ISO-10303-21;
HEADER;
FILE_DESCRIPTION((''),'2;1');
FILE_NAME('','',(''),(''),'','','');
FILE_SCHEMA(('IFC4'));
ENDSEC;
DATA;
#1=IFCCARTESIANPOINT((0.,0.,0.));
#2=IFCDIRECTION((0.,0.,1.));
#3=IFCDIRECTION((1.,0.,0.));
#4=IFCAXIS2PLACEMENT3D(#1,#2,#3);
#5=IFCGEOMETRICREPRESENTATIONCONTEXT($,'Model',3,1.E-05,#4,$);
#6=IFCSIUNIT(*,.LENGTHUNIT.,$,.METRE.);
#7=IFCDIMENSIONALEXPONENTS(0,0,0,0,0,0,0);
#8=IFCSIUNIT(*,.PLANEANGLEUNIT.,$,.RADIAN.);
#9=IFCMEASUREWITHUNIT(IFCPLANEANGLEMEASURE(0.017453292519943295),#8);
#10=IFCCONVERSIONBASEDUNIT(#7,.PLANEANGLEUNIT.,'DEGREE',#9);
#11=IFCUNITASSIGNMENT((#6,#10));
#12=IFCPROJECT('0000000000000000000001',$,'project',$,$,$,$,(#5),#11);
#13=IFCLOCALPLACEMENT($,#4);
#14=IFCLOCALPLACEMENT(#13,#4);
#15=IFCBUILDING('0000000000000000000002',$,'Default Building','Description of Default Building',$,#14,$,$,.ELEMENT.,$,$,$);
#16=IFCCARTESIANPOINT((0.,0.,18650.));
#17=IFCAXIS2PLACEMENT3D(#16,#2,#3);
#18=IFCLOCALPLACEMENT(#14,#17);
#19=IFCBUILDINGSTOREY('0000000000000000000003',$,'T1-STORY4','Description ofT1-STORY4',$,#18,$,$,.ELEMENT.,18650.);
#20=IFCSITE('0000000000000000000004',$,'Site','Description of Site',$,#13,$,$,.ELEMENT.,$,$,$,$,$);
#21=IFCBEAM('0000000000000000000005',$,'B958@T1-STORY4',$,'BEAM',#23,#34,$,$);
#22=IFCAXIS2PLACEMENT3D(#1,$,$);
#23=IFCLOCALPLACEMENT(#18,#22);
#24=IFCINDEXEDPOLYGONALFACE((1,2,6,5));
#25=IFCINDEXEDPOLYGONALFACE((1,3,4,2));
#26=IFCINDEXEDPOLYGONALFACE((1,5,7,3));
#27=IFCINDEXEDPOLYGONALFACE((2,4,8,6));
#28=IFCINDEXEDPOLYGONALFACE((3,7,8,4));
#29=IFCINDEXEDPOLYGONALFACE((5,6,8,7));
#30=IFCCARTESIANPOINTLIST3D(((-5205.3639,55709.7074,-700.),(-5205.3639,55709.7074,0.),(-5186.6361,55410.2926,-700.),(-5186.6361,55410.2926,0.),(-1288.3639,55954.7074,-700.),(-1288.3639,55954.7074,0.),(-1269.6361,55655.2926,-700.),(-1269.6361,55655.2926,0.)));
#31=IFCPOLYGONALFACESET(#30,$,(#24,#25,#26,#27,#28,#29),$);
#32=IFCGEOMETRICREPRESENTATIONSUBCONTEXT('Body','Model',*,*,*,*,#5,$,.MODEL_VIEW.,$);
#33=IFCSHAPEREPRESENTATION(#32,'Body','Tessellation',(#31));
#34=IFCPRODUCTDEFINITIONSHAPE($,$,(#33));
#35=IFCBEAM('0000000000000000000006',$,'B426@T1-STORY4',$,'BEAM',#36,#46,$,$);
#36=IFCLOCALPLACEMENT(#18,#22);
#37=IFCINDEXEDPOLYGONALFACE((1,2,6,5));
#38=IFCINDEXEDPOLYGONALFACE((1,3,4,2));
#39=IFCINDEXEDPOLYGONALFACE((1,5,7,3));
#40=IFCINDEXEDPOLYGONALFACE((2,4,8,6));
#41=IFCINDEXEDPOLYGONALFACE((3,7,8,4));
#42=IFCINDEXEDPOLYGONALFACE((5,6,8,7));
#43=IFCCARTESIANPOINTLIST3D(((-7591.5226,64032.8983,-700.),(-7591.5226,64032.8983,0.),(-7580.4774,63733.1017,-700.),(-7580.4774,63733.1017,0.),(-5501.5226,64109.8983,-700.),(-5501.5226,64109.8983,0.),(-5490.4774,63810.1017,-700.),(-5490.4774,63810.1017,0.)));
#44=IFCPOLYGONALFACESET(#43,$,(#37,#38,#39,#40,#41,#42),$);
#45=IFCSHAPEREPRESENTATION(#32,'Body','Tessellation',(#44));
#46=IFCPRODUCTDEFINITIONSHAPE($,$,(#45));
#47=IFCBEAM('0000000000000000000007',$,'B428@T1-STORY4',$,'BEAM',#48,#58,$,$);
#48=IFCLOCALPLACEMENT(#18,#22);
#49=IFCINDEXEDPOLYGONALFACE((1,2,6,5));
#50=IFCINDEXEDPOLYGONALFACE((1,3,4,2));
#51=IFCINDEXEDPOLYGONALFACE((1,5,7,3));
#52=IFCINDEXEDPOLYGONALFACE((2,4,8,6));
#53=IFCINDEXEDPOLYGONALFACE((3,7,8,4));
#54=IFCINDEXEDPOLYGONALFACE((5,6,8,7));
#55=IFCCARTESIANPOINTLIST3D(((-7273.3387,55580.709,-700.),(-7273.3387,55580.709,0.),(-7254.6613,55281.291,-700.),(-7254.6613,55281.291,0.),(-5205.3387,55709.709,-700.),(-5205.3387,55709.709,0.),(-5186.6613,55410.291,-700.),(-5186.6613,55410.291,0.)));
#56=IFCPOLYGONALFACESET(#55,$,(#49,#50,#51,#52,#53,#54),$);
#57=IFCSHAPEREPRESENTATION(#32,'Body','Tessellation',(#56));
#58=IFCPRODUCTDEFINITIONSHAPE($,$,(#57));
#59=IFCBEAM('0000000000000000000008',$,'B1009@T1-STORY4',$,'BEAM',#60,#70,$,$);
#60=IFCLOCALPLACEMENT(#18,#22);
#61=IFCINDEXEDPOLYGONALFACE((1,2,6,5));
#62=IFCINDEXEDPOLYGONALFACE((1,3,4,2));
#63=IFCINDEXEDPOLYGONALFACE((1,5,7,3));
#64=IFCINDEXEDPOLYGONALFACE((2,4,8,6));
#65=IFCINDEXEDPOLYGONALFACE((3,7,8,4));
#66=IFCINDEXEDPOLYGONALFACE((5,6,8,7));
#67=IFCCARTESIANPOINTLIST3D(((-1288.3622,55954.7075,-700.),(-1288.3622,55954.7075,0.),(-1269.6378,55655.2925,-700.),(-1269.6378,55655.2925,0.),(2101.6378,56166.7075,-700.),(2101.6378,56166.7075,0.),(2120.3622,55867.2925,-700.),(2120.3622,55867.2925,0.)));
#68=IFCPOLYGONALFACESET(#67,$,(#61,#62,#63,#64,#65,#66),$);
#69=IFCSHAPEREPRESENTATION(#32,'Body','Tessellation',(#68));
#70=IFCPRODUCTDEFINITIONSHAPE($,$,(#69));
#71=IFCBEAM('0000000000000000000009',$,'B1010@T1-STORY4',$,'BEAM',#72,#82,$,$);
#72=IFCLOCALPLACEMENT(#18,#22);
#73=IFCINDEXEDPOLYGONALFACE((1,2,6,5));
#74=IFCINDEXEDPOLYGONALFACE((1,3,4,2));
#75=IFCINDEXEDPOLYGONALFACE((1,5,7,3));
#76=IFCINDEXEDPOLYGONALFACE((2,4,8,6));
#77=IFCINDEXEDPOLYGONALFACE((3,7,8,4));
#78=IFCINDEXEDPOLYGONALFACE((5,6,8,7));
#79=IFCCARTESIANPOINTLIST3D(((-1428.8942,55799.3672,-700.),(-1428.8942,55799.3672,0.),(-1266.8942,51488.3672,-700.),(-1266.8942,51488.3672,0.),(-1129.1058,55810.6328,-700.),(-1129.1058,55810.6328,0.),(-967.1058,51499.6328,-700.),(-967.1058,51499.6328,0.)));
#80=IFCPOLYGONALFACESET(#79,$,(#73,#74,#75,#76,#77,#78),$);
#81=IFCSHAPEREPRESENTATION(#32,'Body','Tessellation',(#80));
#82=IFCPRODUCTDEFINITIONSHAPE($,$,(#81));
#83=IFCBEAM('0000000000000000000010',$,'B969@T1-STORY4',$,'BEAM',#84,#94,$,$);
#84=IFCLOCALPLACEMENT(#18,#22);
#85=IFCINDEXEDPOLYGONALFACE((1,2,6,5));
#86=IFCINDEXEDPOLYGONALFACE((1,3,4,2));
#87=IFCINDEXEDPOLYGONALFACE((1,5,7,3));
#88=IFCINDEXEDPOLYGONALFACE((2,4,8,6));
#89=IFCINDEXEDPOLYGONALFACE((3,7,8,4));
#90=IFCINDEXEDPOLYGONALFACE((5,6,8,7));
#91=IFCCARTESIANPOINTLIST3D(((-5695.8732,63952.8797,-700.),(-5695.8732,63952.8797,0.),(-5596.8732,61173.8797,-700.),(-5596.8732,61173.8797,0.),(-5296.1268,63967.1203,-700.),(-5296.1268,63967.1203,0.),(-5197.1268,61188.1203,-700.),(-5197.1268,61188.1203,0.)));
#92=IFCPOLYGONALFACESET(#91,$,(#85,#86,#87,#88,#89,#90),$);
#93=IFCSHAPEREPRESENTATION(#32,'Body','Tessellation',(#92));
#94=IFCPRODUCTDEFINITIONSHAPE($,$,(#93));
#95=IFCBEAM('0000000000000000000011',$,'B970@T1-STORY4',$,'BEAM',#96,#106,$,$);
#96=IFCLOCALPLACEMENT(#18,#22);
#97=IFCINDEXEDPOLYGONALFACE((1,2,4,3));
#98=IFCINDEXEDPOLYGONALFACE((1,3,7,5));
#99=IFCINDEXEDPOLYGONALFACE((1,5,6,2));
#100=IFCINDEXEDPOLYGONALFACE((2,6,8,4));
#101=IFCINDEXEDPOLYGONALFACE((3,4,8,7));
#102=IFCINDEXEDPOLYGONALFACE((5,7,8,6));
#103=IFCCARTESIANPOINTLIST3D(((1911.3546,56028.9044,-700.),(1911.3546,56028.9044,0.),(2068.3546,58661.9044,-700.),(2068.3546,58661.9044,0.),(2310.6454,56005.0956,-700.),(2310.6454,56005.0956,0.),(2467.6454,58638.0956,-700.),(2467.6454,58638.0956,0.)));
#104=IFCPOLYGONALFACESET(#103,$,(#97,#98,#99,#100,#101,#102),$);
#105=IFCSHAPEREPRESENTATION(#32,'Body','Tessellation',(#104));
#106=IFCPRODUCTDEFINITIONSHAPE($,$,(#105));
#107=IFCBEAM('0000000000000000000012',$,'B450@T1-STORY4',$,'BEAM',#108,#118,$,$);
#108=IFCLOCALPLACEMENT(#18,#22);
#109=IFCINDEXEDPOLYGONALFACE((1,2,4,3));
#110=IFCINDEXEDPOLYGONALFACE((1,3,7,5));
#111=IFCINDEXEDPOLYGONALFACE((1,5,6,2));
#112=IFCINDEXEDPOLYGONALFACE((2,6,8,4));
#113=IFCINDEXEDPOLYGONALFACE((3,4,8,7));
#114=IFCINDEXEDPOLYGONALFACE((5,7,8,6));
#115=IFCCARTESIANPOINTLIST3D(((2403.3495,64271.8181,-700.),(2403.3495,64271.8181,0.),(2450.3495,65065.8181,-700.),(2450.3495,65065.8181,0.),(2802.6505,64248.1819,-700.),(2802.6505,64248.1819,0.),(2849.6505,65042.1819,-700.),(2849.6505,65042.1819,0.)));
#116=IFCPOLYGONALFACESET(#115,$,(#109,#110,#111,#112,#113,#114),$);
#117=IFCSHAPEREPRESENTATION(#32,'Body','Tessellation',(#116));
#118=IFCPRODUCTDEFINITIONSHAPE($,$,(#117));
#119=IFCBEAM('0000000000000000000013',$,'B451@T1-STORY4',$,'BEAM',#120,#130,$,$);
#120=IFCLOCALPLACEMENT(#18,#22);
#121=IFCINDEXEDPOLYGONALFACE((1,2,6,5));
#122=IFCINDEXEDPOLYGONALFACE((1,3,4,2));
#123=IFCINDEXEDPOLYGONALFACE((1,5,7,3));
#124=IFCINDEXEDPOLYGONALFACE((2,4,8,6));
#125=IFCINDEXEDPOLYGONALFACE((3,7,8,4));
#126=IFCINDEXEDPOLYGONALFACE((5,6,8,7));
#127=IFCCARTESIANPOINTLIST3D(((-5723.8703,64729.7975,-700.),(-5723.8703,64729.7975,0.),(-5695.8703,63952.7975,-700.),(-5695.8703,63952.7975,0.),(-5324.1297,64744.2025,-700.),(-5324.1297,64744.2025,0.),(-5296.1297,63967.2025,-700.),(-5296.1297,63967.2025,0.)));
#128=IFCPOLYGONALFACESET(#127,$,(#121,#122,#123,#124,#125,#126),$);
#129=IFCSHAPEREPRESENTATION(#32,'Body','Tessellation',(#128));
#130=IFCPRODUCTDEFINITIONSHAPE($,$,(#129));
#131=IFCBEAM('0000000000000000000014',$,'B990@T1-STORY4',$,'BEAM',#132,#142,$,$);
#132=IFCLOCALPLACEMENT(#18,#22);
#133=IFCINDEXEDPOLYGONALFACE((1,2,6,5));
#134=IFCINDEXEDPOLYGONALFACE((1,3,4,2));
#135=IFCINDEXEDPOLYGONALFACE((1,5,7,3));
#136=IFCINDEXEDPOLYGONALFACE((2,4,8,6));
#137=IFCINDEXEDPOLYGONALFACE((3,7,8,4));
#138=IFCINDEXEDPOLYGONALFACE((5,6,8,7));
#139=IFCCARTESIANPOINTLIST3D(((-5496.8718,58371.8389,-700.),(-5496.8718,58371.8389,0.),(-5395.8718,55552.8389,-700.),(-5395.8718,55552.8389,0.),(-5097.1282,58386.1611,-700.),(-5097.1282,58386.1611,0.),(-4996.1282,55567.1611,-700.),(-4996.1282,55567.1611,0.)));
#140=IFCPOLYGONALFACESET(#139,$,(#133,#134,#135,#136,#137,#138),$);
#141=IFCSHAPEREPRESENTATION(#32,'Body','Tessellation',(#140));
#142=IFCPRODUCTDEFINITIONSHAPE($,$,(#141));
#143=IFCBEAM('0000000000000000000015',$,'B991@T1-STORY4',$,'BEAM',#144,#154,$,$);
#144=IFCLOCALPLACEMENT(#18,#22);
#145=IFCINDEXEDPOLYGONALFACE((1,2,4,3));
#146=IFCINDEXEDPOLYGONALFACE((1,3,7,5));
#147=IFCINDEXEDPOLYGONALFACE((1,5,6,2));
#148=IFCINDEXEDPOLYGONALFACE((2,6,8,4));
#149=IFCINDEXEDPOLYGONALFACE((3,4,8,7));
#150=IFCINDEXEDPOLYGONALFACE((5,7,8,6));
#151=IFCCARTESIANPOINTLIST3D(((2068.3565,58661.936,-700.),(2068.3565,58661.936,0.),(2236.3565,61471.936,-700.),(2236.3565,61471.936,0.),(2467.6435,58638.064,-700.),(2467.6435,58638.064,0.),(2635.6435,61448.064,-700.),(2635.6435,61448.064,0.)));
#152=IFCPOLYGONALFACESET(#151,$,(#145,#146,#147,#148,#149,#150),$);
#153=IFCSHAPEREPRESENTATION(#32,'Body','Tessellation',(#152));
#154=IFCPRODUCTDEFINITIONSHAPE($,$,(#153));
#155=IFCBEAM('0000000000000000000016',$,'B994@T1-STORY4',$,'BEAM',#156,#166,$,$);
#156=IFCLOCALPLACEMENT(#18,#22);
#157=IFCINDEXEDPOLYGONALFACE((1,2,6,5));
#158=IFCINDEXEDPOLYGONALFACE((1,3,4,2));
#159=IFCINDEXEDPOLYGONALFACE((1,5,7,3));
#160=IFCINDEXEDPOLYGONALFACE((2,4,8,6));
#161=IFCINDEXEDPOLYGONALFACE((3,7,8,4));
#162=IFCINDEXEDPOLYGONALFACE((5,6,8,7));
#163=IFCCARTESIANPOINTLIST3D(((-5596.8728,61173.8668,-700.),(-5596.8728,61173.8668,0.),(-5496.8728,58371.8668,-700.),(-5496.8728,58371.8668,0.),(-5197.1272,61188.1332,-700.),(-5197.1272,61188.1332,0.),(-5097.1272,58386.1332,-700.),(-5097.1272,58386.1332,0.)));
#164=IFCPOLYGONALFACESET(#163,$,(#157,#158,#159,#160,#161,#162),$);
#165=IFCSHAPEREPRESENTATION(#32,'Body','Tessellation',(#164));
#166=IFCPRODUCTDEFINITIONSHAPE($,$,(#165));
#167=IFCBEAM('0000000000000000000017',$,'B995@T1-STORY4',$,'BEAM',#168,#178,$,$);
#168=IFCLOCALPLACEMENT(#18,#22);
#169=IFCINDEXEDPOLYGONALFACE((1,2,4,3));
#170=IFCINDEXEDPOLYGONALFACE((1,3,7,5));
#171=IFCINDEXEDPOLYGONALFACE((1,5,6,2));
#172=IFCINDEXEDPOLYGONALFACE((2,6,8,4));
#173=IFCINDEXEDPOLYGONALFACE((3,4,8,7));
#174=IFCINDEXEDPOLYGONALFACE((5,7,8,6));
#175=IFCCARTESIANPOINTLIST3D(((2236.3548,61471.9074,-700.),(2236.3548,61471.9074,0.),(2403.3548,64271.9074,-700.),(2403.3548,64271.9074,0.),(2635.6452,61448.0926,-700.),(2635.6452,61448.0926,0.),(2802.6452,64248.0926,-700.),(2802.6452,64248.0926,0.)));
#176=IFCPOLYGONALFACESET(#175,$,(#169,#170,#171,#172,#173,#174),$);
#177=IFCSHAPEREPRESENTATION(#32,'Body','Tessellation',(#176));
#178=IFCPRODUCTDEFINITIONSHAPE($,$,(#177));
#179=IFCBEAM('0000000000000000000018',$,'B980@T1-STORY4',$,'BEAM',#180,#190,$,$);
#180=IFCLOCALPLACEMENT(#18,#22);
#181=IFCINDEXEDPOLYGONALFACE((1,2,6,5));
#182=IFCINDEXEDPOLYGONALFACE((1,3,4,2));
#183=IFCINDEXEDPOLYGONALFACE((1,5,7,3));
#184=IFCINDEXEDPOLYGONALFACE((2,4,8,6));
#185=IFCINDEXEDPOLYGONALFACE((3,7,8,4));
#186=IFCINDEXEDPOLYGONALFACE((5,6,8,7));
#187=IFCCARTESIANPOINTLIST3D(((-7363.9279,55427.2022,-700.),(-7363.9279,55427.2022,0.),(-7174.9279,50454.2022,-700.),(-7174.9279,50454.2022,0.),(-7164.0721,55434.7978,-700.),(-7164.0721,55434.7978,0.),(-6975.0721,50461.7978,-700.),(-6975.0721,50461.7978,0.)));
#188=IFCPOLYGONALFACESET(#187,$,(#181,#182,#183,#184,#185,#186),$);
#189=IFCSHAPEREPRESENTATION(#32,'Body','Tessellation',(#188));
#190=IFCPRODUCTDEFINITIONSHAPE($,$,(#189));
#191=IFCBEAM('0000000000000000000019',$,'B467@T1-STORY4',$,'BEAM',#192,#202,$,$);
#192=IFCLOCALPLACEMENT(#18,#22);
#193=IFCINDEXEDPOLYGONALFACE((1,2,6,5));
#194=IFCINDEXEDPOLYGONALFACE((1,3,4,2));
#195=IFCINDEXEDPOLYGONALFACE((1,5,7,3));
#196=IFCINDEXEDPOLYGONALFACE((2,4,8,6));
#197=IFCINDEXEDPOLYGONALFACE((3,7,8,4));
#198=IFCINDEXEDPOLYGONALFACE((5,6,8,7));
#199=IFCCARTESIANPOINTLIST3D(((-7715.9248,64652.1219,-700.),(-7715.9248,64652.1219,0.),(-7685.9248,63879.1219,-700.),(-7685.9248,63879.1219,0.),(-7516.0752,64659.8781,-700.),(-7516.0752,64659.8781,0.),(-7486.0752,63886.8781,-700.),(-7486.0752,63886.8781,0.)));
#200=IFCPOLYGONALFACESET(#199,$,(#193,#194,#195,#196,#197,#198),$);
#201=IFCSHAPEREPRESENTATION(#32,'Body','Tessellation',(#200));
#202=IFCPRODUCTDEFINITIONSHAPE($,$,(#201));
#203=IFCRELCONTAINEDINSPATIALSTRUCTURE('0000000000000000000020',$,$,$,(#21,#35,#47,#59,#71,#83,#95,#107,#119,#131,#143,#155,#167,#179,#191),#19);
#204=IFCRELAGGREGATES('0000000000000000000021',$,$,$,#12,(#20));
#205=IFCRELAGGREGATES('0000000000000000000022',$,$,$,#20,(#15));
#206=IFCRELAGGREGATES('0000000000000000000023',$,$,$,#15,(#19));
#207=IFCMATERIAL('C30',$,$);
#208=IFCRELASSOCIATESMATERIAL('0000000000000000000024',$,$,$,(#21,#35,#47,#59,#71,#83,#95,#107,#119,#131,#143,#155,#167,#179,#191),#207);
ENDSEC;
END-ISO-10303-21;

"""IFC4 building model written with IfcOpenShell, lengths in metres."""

from ifc_helpers import new_model, entity, si_unit, converted_unit, frame, origin_with_axes, place, context, subcontext, project, spatial, rectangle, extrude, material, element, save


model = new_model("IFC4")

# Units and contexts
model_context = context("Model", 3, precision=1e-05, world=origin_with_axes())
body_context = subcontext(model_context, "Body", "Model", "MODEL_VIEW")
ifc_project = project(units=[si_unit("LENGTHUNIT", "METRE"), converted_unit("PLANEANGLEUNIT", "DEGREE", entity("IfcPlaneAngleMeasure", 0.017453292519943295), si_unit("PLANEANGLEUNIT", "RADIAN"), dimensions=[0, 0, 0, 0, 0, 0, 0])], contexts=[model_context])

# Site, building, storey
site_placement = place(None, origin_with_axes())
site = spatial("IfcSite", under=ifc_project, at=site_placement, Name="Site", Description="Description of Site", CompositionType="ELEMENT")
building_placement = place(site_placement, origin_with_axes())
building = spatial("IfcBuilding", under=site, at=building_placement, Name="Default Building", Description="Description of Default Building", CompositionType="ELEMENT")
storey_placement = place(building_placement, frame((0.0, 0.0, 18650.0), z_axis=(0.0, 0.0, 1.0), x_axis=(1.0, 0.0, 0.0)))
storey = spatial("IfcBuildingStorey", under=building, at=storey_placement, Name="T1-STORY4", Description="Description ofT1-STORY4", CompositionType="ELEMENT", Elevation=18650.0)

# Beams
ifc_material_1 = material(Name="C30")
beam_1_placement = place(storey_placement, frame((-5196.0, 55560.0, -350.0), z_axis=(0.99805, 0.062426, 0.0), x_axis=(-0.062426, 0.99805, 0.0)))
element("IfcBeam", 1, at=beam_1_placement, inside=storey, material=ifc_material_1, Name="B958@T1-STORY4", ObjectType="BEAM", context=body_context, shape_type="SweptSolid", body=[
    extrude(rectangle(XDim=300.0, YDim=700.0), origin_with_axes(), (0.0, 0.0, 1.0), 3924.6546),
])
beam_2_placement = place(storey_placement, frame((-7586.0, 63883.0, -350.0), z_axis=(0.999322, 0.036817, 0.0), x_axis=(-0.036817, 0.999322, 0.0)))
element("IfcBeam", 2, at=beam_2_placement, inside=storey, material=ifc_material_1, Name="B426@T1-STORY4", ObjectType="BEAM", context=body_context, shape_type="SweptSolid", body=[
    extrude(rectangle(XDim=300.0, YDim=700.0), origin_with_axes(), (0.0, 0.0, 1.0), 2091.4179),
])
beam_3_placement = place(storey_placement, frame((-7264.0, 55431.0, -350.0), z_axis=(0.99806, 0.062258, 0.0), x_axis=(-0.062258, 0.99806, 0.0)))
element("IfcBeam", 3, at=beam_3_placement, inside=storey, material=ifc_material_1, Name="B428@T1-STORY4", ObjectType="BEAM", context=body_context, shape_type="SweptSolid", body=[
    extrude(rectangle(XDim=300.0, YDim=700.0), origin_with_axes(), (0.0, 0.0, 1.0), 2072.0195),
])
beam_4_placement = place(storey_placement, frame((-1279.0, 55805.0, -350.0), z_axis=(0.99805, 0.062415, 0.0), x_axis=(-0.062415, 0.99805, 0.0)))
element("IfcBeam", 4, at=beam_4_placement, inside=storey, material=ifc_material_1, Name="B1009@T1-STORY4", ObjectType="BEAM", context=body_context, shape_type="SweptSolid", body=[
    extrude(rectangle(XDim=300.0, YDim=700.0), origin_with_axes(), (0.0, 0.0, 1.0), 3396.6224),
])
beam_5_placement = place(storey_placement, frame((-1279.0, 55805.0, -350.0), z_axis=(0.037552, -0.999295, 0.0), x_axis=(0.999295, 0.037552, 0.0)))
element("IfcBeam", 5, at=beam_5_placement, inside=storey, material=ifc_material_1, Name="B1010@T1-STORY4", ObjectType="BEAM", context=body_context, shape_type="SweptSolid", body=[
    extrude(rectangle(XDim=300.0, YDim=700.0), origin_with_axes(), (0.0, 0.0, 1.0), 4314.0428),
])
beam_6_placement = place(storey_placement, frame((-5496.0, 63960.0, -350.0), z_axis=(0.035602, -0.999366, 0.0), x_axis=(0.999366, 0.035602, 0.0)))
element("IfcBeam", 6, at=beam_6_placement, inside=storey, material=ifc_material_1, Name="B969@T1-STORY4", ObjectType="BEAM", context=body_context, shape_type="SweptSolid", body=[
    extrude(rectangle(XDim=400.0, YDim=700.0), origin_with_axes(), (0.0, 0.0, 1.0), 2780.7628),
])
beam_7_placement = place(storey_placement, frame((2111.0, 56017.0, -350.0), z_axis=(0.059522, 0.998227, 0.0), x_axis=(-0.998227, 0.059522, 0.0)))
element("IfcBeam", 7, at=beam_7_placement, inside=storey, material=ifc_material_1, Name="B970@T1-STORY4", ObjectType="BEAM", context=body_context, shape_type="SweptSolid", body=[
    extrude(rectangle(XDim=400.0, YDim=700.0), origin_with_axes(), (0.0, 0.0, 1.0), 2637.6766),
])
beam_8_placement = place(storey_placement, frame((2603.0, 64260.0, -350.0), z_axis=(0.059091, 0.998253, 0.0), x_axis=(-0.998253, 0.059091, 0.0)))
element("IfcBeam", 8, at=beam_8_placement, inside=storey, material=ifc_material_1, Name="B450@T1-STORY4", ObjectType="BEAM", context=body_context, shape_type="SweptSolid", body=[
    extrude(rectangle(XDim=400.0, YDim=700.0), origin_with_axes(), (0.0, 0.0, 1.0), 795.3898),
])
beam_9_placement = place(storey_placement, frame((-5524.0, 64737.0, -350.0), z_axis=(0.036013, -0.999351, 0.0), x_axis=(0.999351, 0.036013, 0.0)))
element("IfcBeam", 9, at=beam_9_placement, inside=storey, material=ifc_material_1, Name="B451@T1-STORY4", ObjectType="BEAM", context=body_context, shape_type="SweptSolid", body=[
    extrude(rectangle(XDim=400.0, YDim=700.0), origin_with_axes(), (0.0, 0.0, 1.0), 777.5043),
])
beam_10_placement = place(storey_placement, frame((-5297.0, 58379.0, -350.0), z_axis=(0.035805, -0.999359, 0.0), x_axis=(0.999359, 0.035805, 0.0)))
element("IfcBeam", 10, at=beam_10_placement, inside=storey, material=ifc_material_1, Name="B990@T1-STORY4", ObjectType="BEAM", context=body_context, shape_type="SweptSolid", body=[
    extrude(rectangle(XDim=400.0, YDim=700.0), origin_with_axes(), (0.0, 0.0, 1.0), 2820.8087),
])
beam_11_placement = place(storey_placement, frame((2268.0, 58650.0, -350.0), z_axis=(0.05968, 0.998218, 0.0), x_axis=(-0.998218, 0.05968, 0.0)))
element("IfcBeam", 11, at=beam_11_placement, inside=storey, material=ifc_material_1, Name="B991@T1-STORY4", ObjectType="BEAM", context=body_context, shape_type="SweptSolid", body=[
    extrude(rectangle(XDim=400.0, YDim=700.0), origin_with_axes(), (0.0, 0.0, 1.0), 2815.0176),
])
beam_12_placement = place(storey_placement, frame((-5397.0, 61181.0, -350.0), z_axis=(0.035666, -0.999364, 0.0), x_axis=(0.999364, 0.035666, 0.0)))
element("IfcBeam", 12, at=beam_12_placement, inside=storey, material=ifc_material_1, Name="B994@T1-STORY4", ObjectType="BEAM", context=body_context, shape_type="SweptSolid", body=[
    extrude(rectangle(XDim=400.0, YDim=700.0), origin_with_axes(), (0.0, 0.0, 1.0), 2803.7839),
])
beam_13_placement = place(storey_placement, frame((2436.0, 61460.0, -350.0), z_axis=(0.059537, 0.998226, 0.0), x_axis=(-0.998226, 0.059537, 0.0)))
element("IfcBeam", 13, at=beam_13_placement, inside=storey, material=ifc_material_1, Name="B995@T1-STORY4", ObjectType="BEAM", context=body_context, shape_type="SweptSolid", body=[
    extrude(rectangle(XDim=400.0, YDim=700.0), origin_with_axes(), (0.0, 0.0, 1.0), 2804.9758),
])
beam_14_placement = place(storey_placement, frame((-7264.0, 55431.0, -350.0), z_axis=(0.037978, -0.999279, 0.0), x_axis=(0.999279, 0.037978, 0.0)))
element("IfcBeam", 14, at=beam_14_placement, inside=storey, material=ifc_material_1, Name="B980@T1-STORY4", ObjectType="BEAM", context=body_context, shape_type="SweptSolid", body=[
    extrude(rectangle(XDim=200.0, YDim=700.0), origin_with_axes(), (0.0, 0.0, 1.0), 4976.5902),
])
beam_15_placement = place(storey_placement, frame((-7616.0, 64656.0, -350.0), z_axis=(0.038781, -0.999248, 0.0), x_axis=(0.999248, 0.038781, 0.0)))
element("IfcBeam", 15, at=beam_15_placement, inside=storey, material=ifc_material_1, Name="B467@T1-STORY4", ObjectType="BEAM", context=body_context, shape_type="SweptSolid", body=[
    extrude(rectangle(XDim=200.0, YDim=700.0), origin_with_axes(), (0.0, 0.0, 1.0), 773.5819),
])

save(model, "model.ifc")
